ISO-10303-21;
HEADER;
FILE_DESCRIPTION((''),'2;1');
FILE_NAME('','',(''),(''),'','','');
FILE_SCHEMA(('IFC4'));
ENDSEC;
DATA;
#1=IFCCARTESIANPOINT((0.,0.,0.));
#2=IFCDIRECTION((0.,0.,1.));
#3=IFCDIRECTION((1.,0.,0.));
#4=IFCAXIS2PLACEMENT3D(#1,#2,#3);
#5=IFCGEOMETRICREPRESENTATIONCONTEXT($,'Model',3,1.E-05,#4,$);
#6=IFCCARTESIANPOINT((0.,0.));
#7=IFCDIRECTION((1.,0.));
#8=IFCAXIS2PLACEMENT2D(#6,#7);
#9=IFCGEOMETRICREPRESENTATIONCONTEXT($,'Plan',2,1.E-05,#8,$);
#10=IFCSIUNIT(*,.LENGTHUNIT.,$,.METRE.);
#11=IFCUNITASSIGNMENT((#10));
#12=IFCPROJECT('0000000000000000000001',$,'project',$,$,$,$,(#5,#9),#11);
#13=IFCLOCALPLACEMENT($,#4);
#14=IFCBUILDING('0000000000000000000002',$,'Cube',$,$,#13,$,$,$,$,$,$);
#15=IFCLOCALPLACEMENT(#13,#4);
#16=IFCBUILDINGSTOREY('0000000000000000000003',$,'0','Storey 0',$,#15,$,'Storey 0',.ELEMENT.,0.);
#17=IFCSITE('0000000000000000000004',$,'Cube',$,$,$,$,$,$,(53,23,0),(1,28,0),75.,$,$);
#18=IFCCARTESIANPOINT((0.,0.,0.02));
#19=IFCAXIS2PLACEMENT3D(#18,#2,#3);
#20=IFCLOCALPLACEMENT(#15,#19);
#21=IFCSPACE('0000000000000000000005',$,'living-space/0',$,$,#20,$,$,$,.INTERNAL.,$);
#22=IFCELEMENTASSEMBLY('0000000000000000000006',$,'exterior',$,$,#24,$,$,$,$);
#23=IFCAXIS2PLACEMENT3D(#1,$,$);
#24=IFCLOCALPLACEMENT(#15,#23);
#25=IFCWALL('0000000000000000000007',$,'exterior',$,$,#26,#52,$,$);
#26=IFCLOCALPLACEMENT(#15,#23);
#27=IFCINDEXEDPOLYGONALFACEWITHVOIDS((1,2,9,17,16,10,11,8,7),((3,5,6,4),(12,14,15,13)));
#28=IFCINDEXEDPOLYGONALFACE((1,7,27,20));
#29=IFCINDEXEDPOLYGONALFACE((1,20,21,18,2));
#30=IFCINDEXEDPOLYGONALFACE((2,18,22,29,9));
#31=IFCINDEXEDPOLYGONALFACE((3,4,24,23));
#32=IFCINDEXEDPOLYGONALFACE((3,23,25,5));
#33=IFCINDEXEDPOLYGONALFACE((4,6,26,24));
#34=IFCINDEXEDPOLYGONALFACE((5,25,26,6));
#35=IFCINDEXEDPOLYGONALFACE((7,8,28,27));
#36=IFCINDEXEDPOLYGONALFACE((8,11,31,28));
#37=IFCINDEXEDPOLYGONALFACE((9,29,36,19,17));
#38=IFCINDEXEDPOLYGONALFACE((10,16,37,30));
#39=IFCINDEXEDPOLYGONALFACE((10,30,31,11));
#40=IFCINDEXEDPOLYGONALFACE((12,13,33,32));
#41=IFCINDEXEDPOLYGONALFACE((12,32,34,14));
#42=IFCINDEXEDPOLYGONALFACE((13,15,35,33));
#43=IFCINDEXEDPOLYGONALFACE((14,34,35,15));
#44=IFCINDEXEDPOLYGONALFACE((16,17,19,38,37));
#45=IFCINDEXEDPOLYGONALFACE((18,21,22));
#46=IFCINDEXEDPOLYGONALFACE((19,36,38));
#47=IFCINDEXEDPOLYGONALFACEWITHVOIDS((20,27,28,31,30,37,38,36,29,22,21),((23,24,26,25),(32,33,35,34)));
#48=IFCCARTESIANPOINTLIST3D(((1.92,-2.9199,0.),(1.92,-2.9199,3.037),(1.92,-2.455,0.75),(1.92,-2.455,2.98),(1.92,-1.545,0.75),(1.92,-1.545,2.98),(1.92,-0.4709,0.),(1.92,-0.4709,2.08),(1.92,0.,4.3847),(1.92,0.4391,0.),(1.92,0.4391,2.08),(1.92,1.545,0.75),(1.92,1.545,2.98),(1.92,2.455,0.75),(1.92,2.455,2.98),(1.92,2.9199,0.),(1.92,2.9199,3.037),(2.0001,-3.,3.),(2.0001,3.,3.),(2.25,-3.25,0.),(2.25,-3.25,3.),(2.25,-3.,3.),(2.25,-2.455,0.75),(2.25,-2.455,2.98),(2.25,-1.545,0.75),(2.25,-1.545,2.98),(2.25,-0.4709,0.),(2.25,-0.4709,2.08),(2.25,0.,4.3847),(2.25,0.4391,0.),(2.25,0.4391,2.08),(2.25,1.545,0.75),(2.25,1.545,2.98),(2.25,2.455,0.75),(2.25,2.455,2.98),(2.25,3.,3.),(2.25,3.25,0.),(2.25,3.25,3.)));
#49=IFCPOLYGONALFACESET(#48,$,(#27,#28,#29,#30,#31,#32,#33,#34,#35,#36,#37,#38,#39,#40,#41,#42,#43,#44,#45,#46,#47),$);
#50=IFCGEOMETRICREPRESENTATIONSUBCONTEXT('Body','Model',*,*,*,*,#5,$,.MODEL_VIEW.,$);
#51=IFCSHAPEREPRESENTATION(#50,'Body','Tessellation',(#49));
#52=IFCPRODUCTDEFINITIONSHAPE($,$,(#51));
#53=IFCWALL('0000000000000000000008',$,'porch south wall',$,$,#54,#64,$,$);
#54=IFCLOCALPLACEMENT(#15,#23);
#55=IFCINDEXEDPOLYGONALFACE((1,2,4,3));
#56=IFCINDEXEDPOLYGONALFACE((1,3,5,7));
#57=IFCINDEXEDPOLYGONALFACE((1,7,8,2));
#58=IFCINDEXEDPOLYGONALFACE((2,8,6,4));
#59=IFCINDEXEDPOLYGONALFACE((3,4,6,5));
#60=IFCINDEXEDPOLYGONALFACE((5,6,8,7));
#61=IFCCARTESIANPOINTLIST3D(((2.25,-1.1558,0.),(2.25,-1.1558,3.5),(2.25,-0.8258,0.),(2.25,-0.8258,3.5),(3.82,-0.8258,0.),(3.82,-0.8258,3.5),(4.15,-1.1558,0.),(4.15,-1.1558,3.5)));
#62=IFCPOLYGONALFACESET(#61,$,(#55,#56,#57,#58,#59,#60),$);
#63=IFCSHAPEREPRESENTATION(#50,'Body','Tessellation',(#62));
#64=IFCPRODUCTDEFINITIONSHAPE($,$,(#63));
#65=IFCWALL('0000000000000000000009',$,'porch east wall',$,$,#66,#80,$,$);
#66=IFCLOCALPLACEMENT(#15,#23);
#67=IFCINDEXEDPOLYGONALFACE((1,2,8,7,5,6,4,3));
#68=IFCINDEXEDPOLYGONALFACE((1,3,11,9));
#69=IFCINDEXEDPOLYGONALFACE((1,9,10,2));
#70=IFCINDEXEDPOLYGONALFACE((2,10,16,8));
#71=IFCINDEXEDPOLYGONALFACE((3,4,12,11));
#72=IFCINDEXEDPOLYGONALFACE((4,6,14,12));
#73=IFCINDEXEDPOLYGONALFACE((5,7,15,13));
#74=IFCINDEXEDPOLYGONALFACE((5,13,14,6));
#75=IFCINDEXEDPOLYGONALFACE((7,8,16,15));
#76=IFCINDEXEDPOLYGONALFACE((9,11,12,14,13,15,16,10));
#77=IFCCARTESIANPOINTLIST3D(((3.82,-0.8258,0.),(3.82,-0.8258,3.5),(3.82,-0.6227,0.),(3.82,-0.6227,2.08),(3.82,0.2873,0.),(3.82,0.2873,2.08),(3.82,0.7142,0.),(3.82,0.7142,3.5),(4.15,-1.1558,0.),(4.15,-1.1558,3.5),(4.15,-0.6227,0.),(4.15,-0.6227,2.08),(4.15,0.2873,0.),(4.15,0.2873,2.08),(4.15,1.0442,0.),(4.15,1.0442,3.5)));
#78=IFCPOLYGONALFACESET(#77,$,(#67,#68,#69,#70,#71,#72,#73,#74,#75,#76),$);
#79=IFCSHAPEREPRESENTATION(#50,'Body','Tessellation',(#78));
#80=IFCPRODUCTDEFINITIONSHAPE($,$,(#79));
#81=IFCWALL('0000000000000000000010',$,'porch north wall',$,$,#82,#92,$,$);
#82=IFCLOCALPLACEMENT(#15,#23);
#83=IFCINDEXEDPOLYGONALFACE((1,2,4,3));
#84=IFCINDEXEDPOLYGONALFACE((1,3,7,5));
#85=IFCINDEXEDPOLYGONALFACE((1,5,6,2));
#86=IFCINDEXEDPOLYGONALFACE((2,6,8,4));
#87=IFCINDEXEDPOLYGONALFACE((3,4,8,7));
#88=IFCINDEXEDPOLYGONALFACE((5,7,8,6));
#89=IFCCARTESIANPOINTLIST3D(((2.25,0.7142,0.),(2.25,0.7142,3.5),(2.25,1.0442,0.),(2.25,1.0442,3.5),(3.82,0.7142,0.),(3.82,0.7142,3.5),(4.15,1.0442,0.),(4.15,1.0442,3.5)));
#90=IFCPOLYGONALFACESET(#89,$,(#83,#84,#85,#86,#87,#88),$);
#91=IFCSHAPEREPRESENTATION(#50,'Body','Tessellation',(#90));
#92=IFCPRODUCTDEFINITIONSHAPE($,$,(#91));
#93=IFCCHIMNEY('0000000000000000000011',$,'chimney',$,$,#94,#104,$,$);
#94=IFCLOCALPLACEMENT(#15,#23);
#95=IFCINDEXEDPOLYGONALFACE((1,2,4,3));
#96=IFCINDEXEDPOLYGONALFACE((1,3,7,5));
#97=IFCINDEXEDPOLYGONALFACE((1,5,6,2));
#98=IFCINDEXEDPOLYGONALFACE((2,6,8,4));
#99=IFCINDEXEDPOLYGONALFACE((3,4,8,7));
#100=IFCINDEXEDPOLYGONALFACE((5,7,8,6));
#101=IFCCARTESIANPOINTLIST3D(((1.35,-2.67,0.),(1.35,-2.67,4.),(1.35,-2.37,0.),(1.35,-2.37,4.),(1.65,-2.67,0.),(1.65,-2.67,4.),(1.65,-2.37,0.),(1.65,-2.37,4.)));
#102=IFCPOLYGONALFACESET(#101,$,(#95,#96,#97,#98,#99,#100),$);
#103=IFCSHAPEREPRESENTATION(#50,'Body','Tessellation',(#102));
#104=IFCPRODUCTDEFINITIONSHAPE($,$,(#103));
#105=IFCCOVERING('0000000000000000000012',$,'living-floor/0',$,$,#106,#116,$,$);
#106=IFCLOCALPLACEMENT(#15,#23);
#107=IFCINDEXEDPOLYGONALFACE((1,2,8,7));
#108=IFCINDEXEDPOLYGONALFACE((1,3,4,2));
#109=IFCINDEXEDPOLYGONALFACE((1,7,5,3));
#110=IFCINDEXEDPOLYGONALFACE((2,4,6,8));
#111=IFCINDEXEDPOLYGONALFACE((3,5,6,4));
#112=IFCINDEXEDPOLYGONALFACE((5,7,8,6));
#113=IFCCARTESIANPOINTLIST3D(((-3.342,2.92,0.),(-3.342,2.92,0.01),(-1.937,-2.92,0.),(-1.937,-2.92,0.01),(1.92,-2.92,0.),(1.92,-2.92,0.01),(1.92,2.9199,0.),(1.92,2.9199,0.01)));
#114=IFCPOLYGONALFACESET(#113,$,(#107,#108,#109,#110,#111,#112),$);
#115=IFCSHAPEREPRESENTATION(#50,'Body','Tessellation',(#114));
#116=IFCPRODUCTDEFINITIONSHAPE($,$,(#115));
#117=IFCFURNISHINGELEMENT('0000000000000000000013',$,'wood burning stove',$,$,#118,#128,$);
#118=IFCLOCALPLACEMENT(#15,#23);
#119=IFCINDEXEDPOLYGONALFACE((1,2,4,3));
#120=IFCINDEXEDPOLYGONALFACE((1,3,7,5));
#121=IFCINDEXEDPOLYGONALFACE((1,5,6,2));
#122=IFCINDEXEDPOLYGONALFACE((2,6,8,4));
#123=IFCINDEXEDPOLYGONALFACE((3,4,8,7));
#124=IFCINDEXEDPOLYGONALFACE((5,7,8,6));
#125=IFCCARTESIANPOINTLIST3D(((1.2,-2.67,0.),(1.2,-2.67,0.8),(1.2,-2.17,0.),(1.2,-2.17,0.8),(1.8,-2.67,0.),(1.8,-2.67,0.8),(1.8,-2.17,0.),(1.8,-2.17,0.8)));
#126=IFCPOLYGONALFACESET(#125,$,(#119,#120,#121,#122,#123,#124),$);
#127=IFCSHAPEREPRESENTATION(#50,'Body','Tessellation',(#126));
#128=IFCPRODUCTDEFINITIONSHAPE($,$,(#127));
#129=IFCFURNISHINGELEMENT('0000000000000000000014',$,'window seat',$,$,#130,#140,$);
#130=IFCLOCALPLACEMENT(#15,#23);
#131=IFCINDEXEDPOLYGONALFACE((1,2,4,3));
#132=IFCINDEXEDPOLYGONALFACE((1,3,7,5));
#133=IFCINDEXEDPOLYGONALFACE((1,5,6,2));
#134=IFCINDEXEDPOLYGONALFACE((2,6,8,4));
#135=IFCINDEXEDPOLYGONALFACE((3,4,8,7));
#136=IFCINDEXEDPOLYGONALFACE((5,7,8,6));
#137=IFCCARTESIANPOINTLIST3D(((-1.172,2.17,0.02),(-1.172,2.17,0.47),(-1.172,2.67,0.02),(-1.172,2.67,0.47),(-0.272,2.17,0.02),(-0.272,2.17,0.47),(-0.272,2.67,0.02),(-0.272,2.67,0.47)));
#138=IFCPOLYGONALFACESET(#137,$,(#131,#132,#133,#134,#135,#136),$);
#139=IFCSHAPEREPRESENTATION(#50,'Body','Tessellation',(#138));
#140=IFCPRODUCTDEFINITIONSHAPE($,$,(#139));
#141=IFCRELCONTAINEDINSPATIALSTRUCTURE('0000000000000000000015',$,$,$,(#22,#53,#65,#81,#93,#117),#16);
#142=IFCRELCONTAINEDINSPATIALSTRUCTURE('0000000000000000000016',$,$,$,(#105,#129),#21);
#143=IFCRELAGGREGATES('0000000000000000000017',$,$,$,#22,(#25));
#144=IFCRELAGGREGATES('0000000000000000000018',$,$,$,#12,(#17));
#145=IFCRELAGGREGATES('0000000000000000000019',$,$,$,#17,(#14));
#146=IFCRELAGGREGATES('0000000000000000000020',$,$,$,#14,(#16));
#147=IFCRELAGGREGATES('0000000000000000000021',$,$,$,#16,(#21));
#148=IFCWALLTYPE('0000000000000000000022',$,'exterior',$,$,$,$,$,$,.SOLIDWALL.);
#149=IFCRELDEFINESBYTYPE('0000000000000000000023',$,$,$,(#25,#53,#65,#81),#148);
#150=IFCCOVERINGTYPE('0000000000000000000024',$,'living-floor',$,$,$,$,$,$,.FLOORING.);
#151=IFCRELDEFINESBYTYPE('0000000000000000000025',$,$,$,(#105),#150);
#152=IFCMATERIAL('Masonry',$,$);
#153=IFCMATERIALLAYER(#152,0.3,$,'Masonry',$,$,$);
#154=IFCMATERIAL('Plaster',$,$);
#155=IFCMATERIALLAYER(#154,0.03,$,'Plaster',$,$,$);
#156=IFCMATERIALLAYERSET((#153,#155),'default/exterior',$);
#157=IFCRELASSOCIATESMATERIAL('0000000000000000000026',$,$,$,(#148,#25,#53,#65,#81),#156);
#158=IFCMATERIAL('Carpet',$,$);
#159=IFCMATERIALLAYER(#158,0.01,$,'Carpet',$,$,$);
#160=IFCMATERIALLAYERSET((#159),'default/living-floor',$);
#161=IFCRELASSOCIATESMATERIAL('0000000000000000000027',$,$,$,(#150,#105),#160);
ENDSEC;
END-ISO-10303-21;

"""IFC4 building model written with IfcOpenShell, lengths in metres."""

from ifc_helpers import new_model, si_unit, frame, origin, origin_with_axes, origin_2d_with_axis, place, context, subcontext, project, spatial, polyline, line, indexed_curve, outline, extrude, clip, bounded_halfspace, source, transform, mapped, material, layer, layer_set, layer_usage, type_object, element, aggregate, save


model = new_model("IFC4")

# Units and contexts
model_context = context("Model", 3, precision=1e-05, world=origin_with_axes())
plan_context = context("Plan", 2, precision=1e-05, world=origin_2d_with_axis())
body_context = subcontext(model_context, "Body", "Model", "MODEL_VIEW")
ifc_project = project(units=[si_unit("LENGTHUNIT", "METRE")], contexts=[model_context, plan_context])

# Site, building, storey
site = spatial("IfcSite", under=ifc_project, Name="Cube", RefLatitude=(53, 23, 0), RefLongitude=(1, 28, 0), RefElevation=75.0)
building_placement = place(None, origin_with_axes())
building = spatial("IfcBuilding", under=site, at=building_placement, Name="Cube")
storey_placement = place(building_placement, origin_with_axes())
storey = spatial("IfcBuildingStorey", under=building, at=storey_placement, Name="0", Description="Storey 0", LongName="Storey 0", CompositionType="ELEMENT", Elevation=0.0)

# Element assembly, wall, openings
ifc_material_1 = material(Name="Masonry")
ifc_layer_1 = layer(ifc_material_1, 0.3, Name="Masonry")
ifc_material_2 = material(Name="Plaster")
ifc_layer_2 = layer(ifc_material_2, 0.03, Name="Plaster")
ifc_layer_set_1 = layer_set([ifc_layer_1, ifc_layer_2], Name="default/exterior")
wall_type = type_object("IfcWallType", Name="exterior", PredefinedType="SOLIDWALL", material=ifc_layer_set_1)
assembly_1_placement = place(storey_placement, frame((2.0, -3.0, 0.0), z_axis=(0.0, 0.0, 1.0), x_axis=(0.0, 1.0, 0.0)))
assembly_1 = element("IfcElementAssembly", 1, at=assembly_1_placement, inside=storey, Name="exterior")
ifc_layer_usage_1 = layer_usage(ifc_layer_set_1, "AXIS2", "POSITIVE", -0.25)
wall_1_placement = place(assembly_1_placement, origin_with_axes())
wall_1 = element("IfcWall", 2, at=wall_1_placement, type_object=wall_type, material=ifc_layer_usage_1, Name="exterior", context=body_context, shape_type="Clipping", body=[
    clip(clip(clip(clip(extrude(outline(polyline([(0.0801, 0.08), (-0.25, -0.25), (6.25, -0.25), (5.9199, 0.08), (0.0801, 0.08)])), origin(), (0.0, 0.0, 1.0), 4.385), bounded_halfspace(frame((6.0, 0.0, 3.0), z_axis=(0.419069, 0.0, 0.907954), x_axis=(0.0, -1.0, 0.0)), False, origin(), polyline([(6.0, -1.0), (3.0, -1.0), (3.0, 1.0), (6.0, 1.0), (6.0, -1.0)]))), bounded_halfspace(frame((6.0, 0.0, 3.0), z_axis=(0.0, 0.0, 1.0), x_axis=(0.0, 1.0, 0.0)), False, origin(), polyline([(6.0, 1.0), (7.0, 1.0), (7.0, -1.0), (6.0, -1.0), (6.0, 1.0)]))), bounded_halfspace(frame((3.0, 0.0, 4.3847), z_axis=(-0.419069, 0.0, 0.907954), x_axis=(0.0, -1.0, 0.0)), False, origin(), polyline([(3.0, -1.0), (0.0, -1.0), (0.0, 1.0), (3.0, 1.0), (3.0, -1.0)]))), bounded_halfspace(frame((0.0, 0.0, 3.0), z_axis=(0.0, 0.0, 1.0), x_axis=(0.0, -1.0, 0.0)), False, origin(), polyline([(0.0, -1.0), (-1.0, -1.0), (-1.0, 1.0), (0.0, 1.0), (0.0, -1.0)]))),
])
opening_1_placement = place(wall_1_placement, frame((0.545, -0.25, 0.75), z_axis=(0.0, 0.0, 1.0), x_axis=(1.0, 0.0, 0.0)))
element("IfcOpeningElement", 3, at=opening_1_placement, cuts=wall_1, PredefinedType="OPENING", context=body_context, shape_type="SweptSolid", body=[
    extrude(outline(polyline([(0.0, -0.02), (0.91, -0.02), (0.91, 0.35), (0.0, 0.35), (0.0, -0.02)])), origin(), (0.0, 0.0, 1.0), 2.23),
])
opening_2_placement = place(wall_1_placement, frame((4.545, -0.25, 0.75), z_axis=(0.0, 0.0, 1.0), x_axis=(1.0, 0.0, 0.0)))
element("IfcOpeningElement", 4, at=opening_2_placement, cuts=wall_1, PredefinedType="OPENING", context=body_context, shape_type="SweptSolid", body=[
    extrude(outline(polyline([(0.0, -0.02), (0.91, -0.02), (0.91, 0.35), (0.0, 0.35), (0.0, -0.02)])), origin(), (0.0, 0.0, 1.0), 2.23),
])
shared_shape_1 = source(origin_with_axes(), body_context, "Body", "SweptSolid", [
    extrude(outline(indexed_curve([(0.0, 0.0), (0.91, 0.0), (0.91, 2.08), (0.0, 2.08)], segments=[line(1, 2, 3, 4, 1)])), frame((0.0, -0.6, 0.0), z_axis=(0.0, -1.0, 0.0), x_axis=(1.0, 0.0, 0.0)), (0.0, 0.0, -1.0), 1.2),
])
opening_3_placement = place(wall_1_placement, frame((2.5291, -0.25, 0.0), z_axis=(0.0, 0.0, 1.0), x_axis=(1.0, 0.0, 0.0)))
element("IfcOpeningElement", 5, at=opening_3_placement, cuts=wall_1, PredefinedType="OPENING", context=body_context, shape_type="MappedRepresentation", body=[
    mapped(shared_shape_1, transform((0.0, 0.0, 0.0), x_axis=(1.0, 0.0, 0.0), y_axis=(0.0, 1.0, 0.0), z_axis=(0.0, 0.0, 1.0), scale=1.0)),
])
aggregate(assembly_1, [wall_1])

# Wall
ifc_layer_usage_2 = layer_usage(ifc_layer_set_1, "AXIS2", "POSITIVE", 0.0)
wall_2_placement = place(storey_placement, frame((2.25, -1.1558, 0.0), z_axis=(0.0, 0.0, 1.0), x_axis=(1.0, 0.0, 0.0)))
element("IfcWall", 6, at=wall_2_placement, inside=storey, type_object=wall_type, material=ifc_layer_usage_2, Name="porch south wall", context=body_context, shape_type="SweptSolid", body=[
    extrude(outline(indexed_curve([(0.0, 0.0), (0.0, 0.33), (1.57, 0.33), (1.9, 0.0)], segments=[line(1, 2, 3, 4, 1)])), origin_with_axes(), (0.0, 0.0, 1.0), 3.5),
])

# Wall, opening
ifc_layer_usage_3 = layer_usage(ifc_layer_set_1, "AXIS2", "POSITIVE", 0.0)
wall_3_placement = place(storey_placement, frame((4.15, -1.1558, 0.0), z_axis=(0.0, 0.0, 1.0), x_axis=(0.0, 1.0, 0.0)))
wall_3 = element("IfcWall", 7, at=wall_3_placement, inside=storey, type_object=wall_type, material=ifc_layer_usage_3, Name="porch east wall", context=body_context, shape_type="SweptSolid", body=[
    extrude(outline(indexed_curve([(0.0, 0.0), (0.33, 0.33), (1.87, 0.33), (2.2, 0.0)], segments=[line(1, 2, 3, 4, 1)])), origin_with_axes(), (0.0, 0.0, 1.0), 3.5),
])
shared_shape_2 = source(origin_with_axes(), body_context, "Body", "SweptSolid", [
    extrude(outline(indexed_curve([(0.0, 0.0), (0.91, 0.0), (0.91, 2.08), (0.0, 2.08)], segments=[line(1, 2, 3, 4, 1)])), frame((0.0, -0.6, 0.0), z_axis=(0.0, -1.0, 0.0), x_axis=(1.0, 0.0, 0.0)), (0.0, 0.0, -1.0), 1.2),
])
opening_4_placement = place(wall_3_placement, frame((0.5331, 0.0, 0.0), z_axis=(0.0, 0.0, 1.0), x_axis=(1.0, 0.0, 0.0)))
element("IfcOpeningElement", 8, at=opening_4_placement, cuts=wall_3, PredefinedType="OPENING", context=body_context, shape_type="MappedRepresentation", body=[
    mapped(shared_shape_2, transform((0.0, 0.0, 0.0), x_axis=(1.0, 0.0, 0.0), y_axis=(0.0, 1.0, 0.0), z_axis=(0.0, 0.0, 1.0), scale=1.0)),
])

# Wall
ifc_layer_usage_4 = layer_usage(ifc_layer_set_1, "AXIS2", "POSITIVE", 0.0)
wall_4_placement = place(storey_placement, frame((4.15, 1.0442, 0.0), z_axis=(0.0, 0.0, 1.0), x_axis=(-1.0, 0.0, 0.0)))
element("IfcWall", 9, at=wall_4_placement, inside=storey, type_object=wall_type, material=ifc_layer_usage_4, Name="porch north wall", context=body_context, shape_type="SweptSolid", body=[
    extrude(outline(indexed_curve([(0.0, 0.0), (0.33, 0.33), (1.9, 0.33), (1.9, 0.0)], segments=[line(1, 2, 3, 4, 1)])), origin_with_axes(), (0.0, 0.0, 1.0), 3.5),
])

# Chimney
chimney_placement = place(storey_placement, frame((1.35, -2.67, 0.0), z_axis=(0.0, 0.0, 1.0), x_axis=(1.0, 0.0, 0.0)))
element("IfcChimney", 10, at=chimney_placement, inside=storey, Name="chimney", context=body_context, shape_type="SweptSolid", body=[
    extrude(outline(indexed_curve([(0.0, 0.0), (0.3, 0.0), (0.3, 0.3), (0.0, 0.3)])), None, (0.0, 0.0, 1.0), 4.0),
])

# Shared definitions
space_placement = place(storey_placement, frame((0.0, 0.0, 0.02), z_axis=(0.0, 0.0, 1.0), x_axis=(1.0, 0.0, 0.0)))
space = spatial("IfcSpace", under=storey, at=space_placement, Name="living-space/0", PredefinedType="INTERNAL")

# Covering
ifc_material_3 = material(Name="Carpet")
ifc_layer_3 = layer(ifc_material_3, 0.01, Name="Carpet")
ifc_layer_set_2 = layer_set([ifc_layer_3], Name="default/living-floor")
ifc_layer_usage_5 = layer_usage(ifc_layer_set_2, "AXIS3", "POSITIVE", 0.0)
covering_type = type_object("IfcCoveringType", Name="living-floor", PredefinedType="FLOORING", material=ifc_layer_set_2)
covering_placement = place(space_placement, frame((0.0, 0.0, -0.02), z_axis=(0.0, 0.0, 1.0), x_axis=(1.0, 0.0, 0.0)))
element("IfcCovering", 11, at=covering_placement, inside=space, type_object=covering_type, material=ifc_layer_usage_5, Name="living-floor/0", context=body_context, shape_type="SweptSolid", body=[
    extrude(outline(polyline([(1.92, 2.9199), (-3.342, 2.92), (-1.937, -2.92), (1.92, -2.92), (1.92, 2.9199)])), origin_with_axes(), (0.0, 0.0, 1.0), 0.01),
])

# Furnishing elements
furnishing_1_placement = place(storey_placement, frame((1.2, -2.67, 0.0), z_axis=(0.0, 0.0, 1.0), x_axis=(1.0, 0.0, 0.0)))
element("IfcFurnishingElement", 12, at=furnishing_1_placement, inside=storey, Name="wood burning stove", context=body_context, shape_type="SweptSolid", body=[
    extrude(outline(indexed_curve([(0.0, 0.0), (0.6, 0.0), (0.6, 0.5), (0.0, 0.5)])), None, (0.0, 0.0, 1.0), 0.8),
])
furnishing_2_placement = place(space_placement, frame((-1.172, 2.17, 0.0), z_axis=(0.0, 0.0, 1.0), x_axis=(1.0, 0.0, 0.0)))
element("IfcFurnishingElement", 13, at=furnishing_2_placement, inside=space, Name="window seat", context=body_context, shape_type="SweptSolid", body=[
    extrude(outline(indexed_curve([(0.0, 0.0), (0.9, 0.0), (0.9, 0.5), (0.0, 0.5)])), None, (0.0, 0.0, 1.0), 0.45),
])

save(model, "model.ifc")
